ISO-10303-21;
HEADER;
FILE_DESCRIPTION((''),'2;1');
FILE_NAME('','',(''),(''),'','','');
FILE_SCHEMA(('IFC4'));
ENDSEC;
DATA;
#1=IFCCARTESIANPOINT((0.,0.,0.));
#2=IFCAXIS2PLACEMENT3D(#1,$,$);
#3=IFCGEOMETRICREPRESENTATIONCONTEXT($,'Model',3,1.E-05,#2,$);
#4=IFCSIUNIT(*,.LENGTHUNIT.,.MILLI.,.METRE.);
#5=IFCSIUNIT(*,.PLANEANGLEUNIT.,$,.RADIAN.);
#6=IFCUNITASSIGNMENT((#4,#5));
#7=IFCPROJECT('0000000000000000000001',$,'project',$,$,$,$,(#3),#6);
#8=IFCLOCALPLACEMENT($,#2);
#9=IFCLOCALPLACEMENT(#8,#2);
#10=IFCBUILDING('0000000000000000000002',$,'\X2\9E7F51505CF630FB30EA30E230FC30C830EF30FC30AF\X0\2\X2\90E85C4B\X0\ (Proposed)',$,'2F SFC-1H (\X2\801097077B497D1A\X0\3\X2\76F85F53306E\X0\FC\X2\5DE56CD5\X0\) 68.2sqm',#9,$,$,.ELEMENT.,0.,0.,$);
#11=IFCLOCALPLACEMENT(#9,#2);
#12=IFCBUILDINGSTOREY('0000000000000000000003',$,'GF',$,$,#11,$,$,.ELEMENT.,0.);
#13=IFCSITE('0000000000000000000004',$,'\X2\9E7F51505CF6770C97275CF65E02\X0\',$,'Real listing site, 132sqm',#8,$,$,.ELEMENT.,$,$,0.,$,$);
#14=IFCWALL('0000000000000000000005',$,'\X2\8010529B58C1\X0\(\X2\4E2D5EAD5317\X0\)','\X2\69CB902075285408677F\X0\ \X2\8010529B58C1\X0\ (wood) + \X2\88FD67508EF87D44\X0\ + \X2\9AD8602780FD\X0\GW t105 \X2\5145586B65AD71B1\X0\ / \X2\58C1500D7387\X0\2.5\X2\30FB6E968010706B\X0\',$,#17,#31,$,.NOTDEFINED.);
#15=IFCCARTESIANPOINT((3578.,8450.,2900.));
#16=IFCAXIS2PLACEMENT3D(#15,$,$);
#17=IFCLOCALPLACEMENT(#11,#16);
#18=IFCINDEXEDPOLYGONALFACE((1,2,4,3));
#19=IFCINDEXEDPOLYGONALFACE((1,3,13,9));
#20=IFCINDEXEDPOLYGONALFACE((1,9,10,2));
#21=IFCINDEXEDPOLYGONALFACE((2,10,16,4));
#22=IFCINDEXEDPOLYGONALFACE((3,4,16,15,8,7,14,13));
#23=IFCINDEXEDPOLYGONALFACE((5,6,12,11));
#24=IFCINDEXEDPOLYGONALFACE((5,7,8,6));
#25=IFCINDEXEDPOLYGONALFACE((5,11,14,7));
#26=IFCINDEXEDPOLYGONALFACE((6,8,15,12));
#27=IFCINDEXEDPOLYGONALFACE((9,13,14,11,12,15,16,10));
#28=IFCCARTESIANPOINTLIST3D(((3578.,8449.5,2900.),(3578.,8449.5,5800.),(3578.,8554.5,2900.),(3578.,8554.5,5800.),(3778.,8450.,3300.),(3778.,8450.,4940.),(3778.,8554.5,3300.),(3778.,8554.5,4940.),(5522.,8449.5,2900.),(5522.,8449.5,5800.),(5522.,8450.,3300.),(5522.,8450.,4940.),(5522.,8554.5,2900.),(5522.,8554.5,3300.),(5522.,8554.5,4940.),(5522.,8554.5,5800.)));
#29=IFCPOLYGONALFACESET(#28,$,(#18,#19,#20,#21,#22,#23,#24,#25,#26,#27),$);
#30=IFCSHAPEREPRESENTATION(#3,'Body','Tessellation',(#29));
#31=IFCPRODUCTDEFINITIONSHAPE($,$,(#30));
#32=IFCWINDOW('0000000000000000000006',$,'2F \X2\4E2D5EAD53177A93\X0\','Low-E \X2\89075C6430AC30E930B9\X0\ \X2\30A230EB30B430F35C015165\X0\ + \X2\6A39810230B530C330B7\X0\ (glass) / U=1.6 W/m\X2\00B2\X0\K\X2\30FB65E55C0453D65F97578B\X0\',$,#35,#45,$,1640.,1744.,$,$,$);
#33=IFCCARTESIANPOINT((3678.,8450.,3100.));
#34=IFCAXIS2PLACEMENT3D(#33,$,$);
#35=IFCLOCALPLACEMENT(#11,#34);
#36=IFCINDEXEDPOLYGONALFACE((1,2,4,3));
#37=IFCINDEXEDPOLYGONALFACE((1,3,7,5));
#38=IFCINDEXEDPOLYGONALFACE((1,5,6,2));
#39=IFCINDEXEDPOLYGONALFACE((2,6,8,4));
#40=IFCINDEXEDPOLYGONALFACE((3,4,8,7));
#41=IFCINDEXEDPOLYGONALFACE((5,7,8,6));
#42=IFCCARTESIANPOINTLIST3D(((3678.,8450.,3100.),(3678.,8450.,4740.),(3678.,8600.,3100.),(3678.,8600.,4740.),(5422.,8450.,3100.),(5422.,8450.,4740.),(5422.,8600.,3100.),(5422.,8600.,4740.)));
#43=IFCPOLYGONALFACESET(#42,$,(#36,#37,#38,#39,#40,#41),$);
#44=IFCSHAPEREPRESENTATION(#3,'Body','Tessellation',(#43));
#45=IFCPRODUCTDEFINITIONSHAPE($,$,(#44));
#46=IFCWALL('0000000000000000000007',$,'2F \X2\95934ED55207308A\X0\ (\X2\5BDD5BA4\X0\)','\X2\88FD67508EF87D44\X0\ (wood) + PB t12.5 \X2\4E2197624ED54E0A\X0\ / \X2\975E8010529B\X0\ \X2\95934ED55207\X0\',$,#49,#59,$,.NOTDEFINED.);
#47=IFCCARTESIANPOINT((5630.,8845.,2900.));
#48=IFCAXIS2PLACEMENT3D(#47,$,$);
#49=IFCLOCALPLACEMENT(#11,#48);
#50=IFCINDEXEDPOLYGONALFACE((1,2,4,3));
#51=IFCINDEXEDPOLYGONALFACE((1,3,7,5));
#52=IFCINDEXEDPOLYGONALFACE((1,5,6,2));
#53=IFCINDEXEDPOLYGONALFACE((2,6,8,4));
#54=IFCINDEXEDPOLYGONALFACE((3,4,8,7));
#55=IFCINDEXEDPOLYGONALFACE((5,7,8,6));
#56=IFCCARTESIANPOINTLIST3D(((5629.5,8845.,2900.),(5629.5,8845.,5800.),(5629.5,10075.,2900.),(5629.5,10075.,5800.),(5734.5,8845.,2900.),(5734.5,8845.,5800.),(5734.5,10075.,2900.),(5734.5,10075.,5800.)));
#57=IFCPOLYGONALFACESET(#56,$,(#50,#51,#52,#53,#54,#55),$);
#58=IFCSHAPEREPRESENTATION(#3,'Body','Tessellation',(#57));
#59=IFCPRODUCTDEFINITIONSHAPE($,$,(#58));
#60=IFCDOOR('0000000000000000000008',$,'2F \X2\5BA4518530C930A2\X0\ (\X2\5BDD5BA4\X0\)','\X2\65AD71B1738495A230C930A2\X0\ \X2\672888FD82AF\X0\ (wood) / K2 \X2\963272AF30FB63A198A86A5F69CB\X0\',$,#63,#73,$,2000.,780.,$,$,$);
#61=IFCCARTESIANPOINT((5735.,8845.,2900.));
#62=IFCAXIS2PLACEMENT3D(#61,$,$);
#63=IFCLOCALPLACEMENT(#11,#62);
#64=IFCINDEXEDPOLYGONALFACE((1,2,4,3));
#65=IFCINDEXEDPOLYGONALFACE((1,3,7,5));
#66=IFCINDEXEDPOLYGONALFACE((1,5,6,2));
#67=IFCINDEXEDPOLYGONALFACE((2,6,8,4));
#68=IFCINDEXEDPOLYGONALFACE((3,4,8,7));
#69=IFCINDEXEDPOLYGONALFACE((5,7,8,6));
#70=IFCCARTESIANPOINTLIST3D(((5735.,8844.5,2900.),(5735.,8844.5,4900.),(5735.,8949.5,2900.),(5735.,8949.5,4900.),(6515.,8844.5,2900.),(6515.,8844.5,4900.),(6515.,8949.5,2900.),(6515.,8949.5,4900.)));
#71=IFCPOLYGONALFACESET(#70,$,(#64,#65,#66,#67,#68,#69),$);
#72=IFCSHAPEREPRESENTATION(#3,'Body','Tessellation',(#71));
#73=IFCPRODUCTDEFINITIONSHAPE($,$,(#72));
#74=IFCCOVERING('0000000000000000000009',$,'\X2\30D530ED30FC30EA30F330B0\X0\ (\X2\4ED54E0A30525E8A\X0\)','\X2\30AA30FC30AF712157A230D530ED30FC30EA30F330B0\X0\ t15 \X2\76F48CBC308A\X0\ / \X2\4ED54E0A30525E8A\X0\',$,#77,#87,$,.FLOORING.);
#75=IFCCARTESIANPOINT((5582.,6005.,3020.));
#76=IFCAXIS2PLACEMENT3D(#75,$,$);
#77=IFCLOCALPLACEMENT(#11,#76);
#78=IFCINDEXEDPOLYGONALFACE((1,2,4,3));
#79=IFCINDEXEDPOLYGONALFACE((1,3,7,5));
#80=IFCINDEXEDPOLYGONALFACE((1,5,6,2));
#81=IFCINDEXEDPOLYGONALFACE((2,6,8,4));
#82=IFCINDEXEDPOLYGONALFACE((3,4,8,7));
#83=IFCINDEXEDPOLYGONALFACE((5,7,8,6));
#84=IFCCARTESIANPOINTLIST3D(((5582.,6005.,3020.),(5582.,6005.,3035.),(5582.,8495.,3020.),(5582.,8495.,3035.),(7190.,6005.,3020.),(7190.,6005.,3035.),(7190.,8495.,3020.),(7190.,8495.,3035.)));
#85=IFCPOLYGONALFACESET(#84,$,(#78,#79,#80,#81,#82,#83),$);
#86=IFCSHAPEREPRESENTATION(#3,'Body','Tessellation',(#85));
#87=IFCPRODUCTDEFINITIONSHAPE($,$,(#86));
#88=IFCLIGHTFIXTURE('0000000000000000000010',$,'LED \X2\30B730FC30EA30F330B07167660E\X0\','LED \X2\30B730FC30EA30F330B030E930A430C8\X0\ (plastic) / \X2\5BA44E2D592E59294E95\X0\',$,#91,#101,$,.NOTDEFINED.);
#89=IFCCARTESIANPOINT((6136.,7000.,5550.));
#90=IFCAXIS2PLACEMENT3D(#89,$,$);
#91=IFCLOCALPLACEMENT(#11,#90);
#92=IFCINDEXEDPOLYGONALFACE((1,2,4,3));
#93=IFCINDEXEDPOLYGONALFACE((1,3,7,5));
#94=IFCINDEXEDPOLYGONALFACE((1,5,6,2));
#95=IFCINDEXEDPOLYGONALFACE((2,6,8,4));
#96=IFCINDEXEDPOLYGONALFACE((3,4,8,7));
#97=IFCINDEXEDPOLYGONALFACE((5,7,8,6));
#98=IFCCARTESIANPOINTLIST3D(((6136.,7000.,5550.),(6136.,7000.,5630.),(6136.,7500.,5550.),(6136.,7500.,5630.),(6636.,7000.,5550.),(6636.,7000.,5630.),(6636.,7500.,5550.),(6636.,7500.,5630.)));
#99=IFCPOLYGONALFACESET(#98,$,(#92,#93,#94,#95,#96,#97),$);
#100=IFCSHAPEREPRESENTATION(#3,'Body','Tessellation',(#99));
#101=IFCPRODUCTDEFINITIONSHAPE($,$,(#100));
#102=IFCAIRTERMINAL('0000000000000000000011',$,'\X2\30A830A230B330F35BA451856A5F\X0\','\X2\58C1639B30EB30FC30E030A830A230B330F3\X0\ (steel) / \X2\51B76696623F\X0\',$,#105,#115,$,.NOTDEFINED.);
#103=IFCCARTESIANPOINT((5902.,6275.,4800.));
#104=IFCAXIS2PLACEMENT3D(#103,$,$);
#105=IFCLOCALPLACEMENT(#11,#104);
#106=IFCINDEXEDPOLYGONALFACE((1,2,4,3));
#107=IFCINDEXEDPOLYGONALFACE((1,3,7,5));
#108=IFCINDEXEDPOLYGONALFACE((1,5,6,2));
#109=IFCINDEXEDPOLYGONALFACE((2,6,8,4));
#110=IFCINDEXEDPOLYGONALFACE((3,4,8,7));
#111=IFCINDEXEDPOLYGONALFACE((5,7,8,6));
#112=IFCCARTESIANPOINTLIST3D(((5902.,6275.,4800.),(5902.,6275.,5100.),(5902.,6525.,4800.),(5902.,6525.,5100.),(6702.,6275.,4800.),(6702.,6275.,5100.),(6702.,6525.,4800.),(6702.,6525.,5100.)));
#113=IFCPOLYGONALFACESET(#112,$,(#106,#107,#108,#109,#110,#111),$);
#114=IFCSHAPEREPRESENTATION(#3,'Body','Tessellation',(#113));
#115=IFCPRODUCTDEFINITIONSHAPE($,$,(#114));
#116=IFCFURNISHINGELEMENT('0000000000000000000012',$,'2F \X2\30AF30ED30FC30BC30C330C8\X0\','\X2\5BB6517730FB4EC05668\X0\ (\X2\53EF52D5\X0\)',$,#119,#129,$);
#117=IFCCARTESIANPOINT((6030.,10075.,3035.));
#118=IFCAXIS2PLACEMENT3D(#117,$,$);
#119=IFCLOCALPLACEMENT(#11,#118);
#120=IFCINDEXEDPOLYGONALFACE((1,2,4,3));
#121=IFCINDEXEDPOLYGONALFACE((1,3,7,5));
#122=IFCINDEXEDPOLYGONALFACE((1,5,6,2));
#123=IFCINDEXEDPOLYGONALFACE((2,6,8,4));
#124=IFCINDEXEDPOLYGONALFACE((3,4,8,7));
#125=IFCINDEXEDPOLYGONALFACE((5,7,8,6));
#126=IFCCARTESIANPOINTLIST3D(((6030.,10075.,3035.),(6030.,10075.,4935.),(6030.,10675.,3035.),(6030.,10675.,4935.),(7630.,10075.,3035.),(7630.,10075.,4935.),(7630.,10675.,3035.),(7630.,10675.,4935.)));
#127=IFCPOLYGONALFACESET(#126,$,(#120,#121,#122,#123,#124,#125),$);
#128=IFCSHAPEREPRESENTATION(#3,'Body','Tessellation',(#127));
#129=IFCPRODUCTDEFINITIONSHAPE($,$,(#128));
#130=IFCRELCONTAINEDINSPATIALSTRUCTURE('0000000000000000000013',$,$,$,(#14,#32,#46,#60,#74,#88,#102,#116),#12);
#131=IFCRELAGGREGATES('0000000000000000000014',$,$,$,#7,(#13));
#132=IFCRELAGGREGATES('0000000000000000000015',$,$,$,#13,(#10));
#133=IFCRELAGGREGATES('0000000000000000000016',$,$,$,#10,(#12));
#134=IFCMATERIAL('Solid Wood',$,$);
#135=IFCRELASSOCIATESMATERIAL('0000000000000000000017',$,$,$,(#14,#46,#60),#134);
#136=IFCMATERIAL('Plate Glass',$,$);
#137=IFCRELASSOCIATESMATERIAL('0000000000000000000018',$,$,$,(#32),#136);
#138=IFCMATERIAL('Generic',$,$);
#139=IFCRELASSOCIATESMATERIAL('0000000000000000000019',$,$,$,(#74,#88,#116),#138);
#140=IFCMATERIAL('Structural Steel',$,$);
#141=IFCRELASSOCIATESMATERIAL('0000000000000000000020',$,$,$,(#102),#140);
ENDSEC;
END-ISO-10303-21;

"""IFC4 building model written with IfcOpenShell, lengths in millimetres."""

from ifc_helpers import new_model, si_unit, frame, frame_2d, origin, place, context, project, spatial, rectangle, extrude, material, element, fill, save


model = new_model("IFC4")

# Units and contexts
model_context = context("Model", 3, precision=1e-05, world=origin())
ifc_project = project(units=[si_unit("LENGTHUNIT", "METRE", prefix="MILLI"), si_unit("PLANEANGLEUNIT", "RADIAN")], contexts=[model_context])

# Site, building, storey
site_placement = place(None, origin())
site = spatial("IfcSite", under=ifc_project, at=site_placement, Name="鹿児島県霧島市", ObjectType="Real listing site, 132sqm", CompositionType="ELEMENT", RefElevation=0.0)
building_placement = place(site_placement, origin())
building = spatial("IfcBuilding", under=site, at=building_placement, Name="鹿児島・リモートワーク2部屋 (Proposed)", ObjectType="2F SFC-1H (耐震等級3相当のFC工法) 68.2sqm", CompositionType="ELEMENT", ElevationOfRefHeight=0.0, ElevationOfTerrain=0.0)
storey_placement = place(building_placement, origin())
storey = spatial("IfcBuildingStorey", under=building, at=storey_placement, Name="GF", CompositionType="ELEMENT", Elevation=0.0)

# Shared definitions
ifc_material_1 = material(Name="Solid Wood")

# Wall, opening, window
wall_1_placement = place(storey_placement, frame((3578.0, 8450.0, 2900.0)))
wall_1 = element("IfcWall", 1, at=wall_1_placement, inside=storey, material=ifc_material_1, Name="耐力壁(中庭北)", Description="構造用合板 耐力壁 (wood) + 製材軸組 + 高性能GW t105 充填断熱 / 壁倍率2.5・準耐火", PredefinedType="NOTDEFINED", context=model_context, shape_type="SweptSolid", body=[
    extrude(rectangle(XDim=1944.0, YDim=105.0, at=frame_2d((972.0, 52.0))), frame((3578.0, 8450.0, 2900.0)), (0.0, 0.0, 1.0), 2900.0),
])
opening_placement = place(storey_placement, frame((3678.0, 8450.0, 3100.0)))
opening = element("IfcOpeningElement", 2, at=opening_placement, cuts=wall_1, PredefinedType="NOTDEFINED", context=model_context, shape_type="SweptSolid", body=[
    extrude(rectangle(XDim=1744.0, YDim=150.0, at=frame_2d((872.0, 75.0))), frame((3678.0, 8450.0, 3100.0)), (0.0, 0.0, 1.0), 1640.0),
])
ifc_material_2 = material(Name="Plate Glass")
window_placement = place(storey_placement, frame((3678.0, 8450.0, 3100.0)))
window = element("IfcWindow", 3, at=window_placement, inside=storey, material=ifc_material_2, Name="2F 中庭北窓", Description="Low-E 複層ガラス アルゴン封入 + 樹脂サッシ (glass) / U=1.6 W/m²K・日射取得型", OverallHeight=1640.0, OverallWidth=1744.0, context=model_context, shape_type="SweptSolid", body=[
    extrude(rectangle(XDim=1744.0, YDim=150.0, at=frame_2d((872.0, 75.0))), frame((3678.0, 8450.0, 3100.0)), (0.0, 0.0, 1.0), 1640.0),
])
fill(opening, window)

# Wall
wall_2_placement = place(storey_placement, frame((5630.0, 8845.0, 2900.0)))
element("IfcWall", 4, at=wall_2_placement, inside=storey, material=ifc_material_1, Name="2F 間仕切り (寝室)", Description="製材軸組 (wood) + PB t12.5 両面仕上 / 非耐力 間仕切", PredefinedType="NOTDEFINED", context=model_context, shape_type="SweptSolid", body=[
    extrude(rectangle(XDim=105.0, YDim=1230.0, at=frame_2d((52.0, 615.0))), frame((5630.0, 8845.0, 2900.0)), (0.0, 0.0, 1.0), 2900.0),
])

# Door
door_placement = place(storey_placement, frame((5735.0, 8845.0, 2900.0)))
element("IfcDoor", 5, at=door_placement, inside=storey, material=ifc_material_1, Name="2F 室内ドア (寝室)", Description="断熱玄関ドア 木製芯 (wood) / K2 防犯・採風機構", OverallHeight=2000.0, OverallWidth=780.0, context=model_context, shape_type="SweptSolid", body=[
    extrude(rectangle(XDim=780.0, YDim=105.0, at=frame_2d((390.0, 52.0))), frame((5735.0, 8845.0, 2900.0)), (0.0, 0.0, 1.0), 2000.0),
])

# Covering
ifc_material_3 = material(Name="Generic")
covering_placement = place(storey_placement, frame((5582.0, 6005.0, 3020.0)))
element("IfcCovering", 6, at=covering_placement, inside=storey, material=ifc_material_3, Name="フローリング (仕上げ床)", Description="オーク無垢フローリング t15 直貼り / 仕上げ床", PredefinedType="FLOORING", context=model_context, shape_type="SweptSolid", body=[
    extrude(rectangle(XDim=1608.0, YDim=2490.0, at=frame_2d((804.0, 1245.0))), frame((5582.0, 6005.0, 3020.0)), (0.0, 0.0, 1.0), 15.0),
])

# Light fixture
light_fixture_placement = place(storey_placement, frame((6136.0, 7000.0, 5550.0)))
element("IfcLightFixture", 7, at=light_fixture_placement, inside=storey, material=ifc_material_3, Name="LED シーリング照明", Description="LED シーリングライト (plastic) / 室中央天井", PredefinedType="NOTDEFINED", context=model_context, shape_type="SweptSolid", body=[
    extrude(rectangle(XDim=500.0, YDim=500.0, at=frame_2d((250.0, 250.0))), frame((6136.0, 7000.0, 5550.0)), (0.0, 0.0, 1.0), 80.0),
])

# Air terminal
ifc_material_4 = material(Name="Structural Steel")
air_terminal_placement = place(storey_placement, frame((5902.0, 6275.0, 4800.0)))
element("IfcAirTerminal", 8, at=air_terminal_placement, inside=storey, material=ifc_material_4, Name="エアコン室内機", Description="壁掛ルームエアコン (steel) / 冷暖房", PredefinedType="NOTDEFINED", context=model_context, shape_type="SweptSolid", body=[
    extrude(rectangle(XDim=800.0, YDim=250.0, at=frame_2d((400.0, 125.0))), frame((5902.0, 6275.0, 4800.0)), (0.0, 0.0, 1.0), 300.0),
])

# Furnishing element
furnishing_placement = place(storey_placement, frame((6030.0, 10075.0, 3035.0)))
element("IfcFurnishingElement", 9, at=furnishing_placement, inside=storey, material=ifc_material_3, Name="2F クローゼット", Description="家具・什器 (可動)", context=model_context, shape_type="SweptSolid", body=[
    extrude(rectangle(XDim=1600.0, YDim=600.0, at=frame_2d((800.0, 300.0))), frame((6030.0, 10075.0, 3035.0)), (0.0, 0.0, 1.0), 1900.0),
])

save(model, "model.ifc")
